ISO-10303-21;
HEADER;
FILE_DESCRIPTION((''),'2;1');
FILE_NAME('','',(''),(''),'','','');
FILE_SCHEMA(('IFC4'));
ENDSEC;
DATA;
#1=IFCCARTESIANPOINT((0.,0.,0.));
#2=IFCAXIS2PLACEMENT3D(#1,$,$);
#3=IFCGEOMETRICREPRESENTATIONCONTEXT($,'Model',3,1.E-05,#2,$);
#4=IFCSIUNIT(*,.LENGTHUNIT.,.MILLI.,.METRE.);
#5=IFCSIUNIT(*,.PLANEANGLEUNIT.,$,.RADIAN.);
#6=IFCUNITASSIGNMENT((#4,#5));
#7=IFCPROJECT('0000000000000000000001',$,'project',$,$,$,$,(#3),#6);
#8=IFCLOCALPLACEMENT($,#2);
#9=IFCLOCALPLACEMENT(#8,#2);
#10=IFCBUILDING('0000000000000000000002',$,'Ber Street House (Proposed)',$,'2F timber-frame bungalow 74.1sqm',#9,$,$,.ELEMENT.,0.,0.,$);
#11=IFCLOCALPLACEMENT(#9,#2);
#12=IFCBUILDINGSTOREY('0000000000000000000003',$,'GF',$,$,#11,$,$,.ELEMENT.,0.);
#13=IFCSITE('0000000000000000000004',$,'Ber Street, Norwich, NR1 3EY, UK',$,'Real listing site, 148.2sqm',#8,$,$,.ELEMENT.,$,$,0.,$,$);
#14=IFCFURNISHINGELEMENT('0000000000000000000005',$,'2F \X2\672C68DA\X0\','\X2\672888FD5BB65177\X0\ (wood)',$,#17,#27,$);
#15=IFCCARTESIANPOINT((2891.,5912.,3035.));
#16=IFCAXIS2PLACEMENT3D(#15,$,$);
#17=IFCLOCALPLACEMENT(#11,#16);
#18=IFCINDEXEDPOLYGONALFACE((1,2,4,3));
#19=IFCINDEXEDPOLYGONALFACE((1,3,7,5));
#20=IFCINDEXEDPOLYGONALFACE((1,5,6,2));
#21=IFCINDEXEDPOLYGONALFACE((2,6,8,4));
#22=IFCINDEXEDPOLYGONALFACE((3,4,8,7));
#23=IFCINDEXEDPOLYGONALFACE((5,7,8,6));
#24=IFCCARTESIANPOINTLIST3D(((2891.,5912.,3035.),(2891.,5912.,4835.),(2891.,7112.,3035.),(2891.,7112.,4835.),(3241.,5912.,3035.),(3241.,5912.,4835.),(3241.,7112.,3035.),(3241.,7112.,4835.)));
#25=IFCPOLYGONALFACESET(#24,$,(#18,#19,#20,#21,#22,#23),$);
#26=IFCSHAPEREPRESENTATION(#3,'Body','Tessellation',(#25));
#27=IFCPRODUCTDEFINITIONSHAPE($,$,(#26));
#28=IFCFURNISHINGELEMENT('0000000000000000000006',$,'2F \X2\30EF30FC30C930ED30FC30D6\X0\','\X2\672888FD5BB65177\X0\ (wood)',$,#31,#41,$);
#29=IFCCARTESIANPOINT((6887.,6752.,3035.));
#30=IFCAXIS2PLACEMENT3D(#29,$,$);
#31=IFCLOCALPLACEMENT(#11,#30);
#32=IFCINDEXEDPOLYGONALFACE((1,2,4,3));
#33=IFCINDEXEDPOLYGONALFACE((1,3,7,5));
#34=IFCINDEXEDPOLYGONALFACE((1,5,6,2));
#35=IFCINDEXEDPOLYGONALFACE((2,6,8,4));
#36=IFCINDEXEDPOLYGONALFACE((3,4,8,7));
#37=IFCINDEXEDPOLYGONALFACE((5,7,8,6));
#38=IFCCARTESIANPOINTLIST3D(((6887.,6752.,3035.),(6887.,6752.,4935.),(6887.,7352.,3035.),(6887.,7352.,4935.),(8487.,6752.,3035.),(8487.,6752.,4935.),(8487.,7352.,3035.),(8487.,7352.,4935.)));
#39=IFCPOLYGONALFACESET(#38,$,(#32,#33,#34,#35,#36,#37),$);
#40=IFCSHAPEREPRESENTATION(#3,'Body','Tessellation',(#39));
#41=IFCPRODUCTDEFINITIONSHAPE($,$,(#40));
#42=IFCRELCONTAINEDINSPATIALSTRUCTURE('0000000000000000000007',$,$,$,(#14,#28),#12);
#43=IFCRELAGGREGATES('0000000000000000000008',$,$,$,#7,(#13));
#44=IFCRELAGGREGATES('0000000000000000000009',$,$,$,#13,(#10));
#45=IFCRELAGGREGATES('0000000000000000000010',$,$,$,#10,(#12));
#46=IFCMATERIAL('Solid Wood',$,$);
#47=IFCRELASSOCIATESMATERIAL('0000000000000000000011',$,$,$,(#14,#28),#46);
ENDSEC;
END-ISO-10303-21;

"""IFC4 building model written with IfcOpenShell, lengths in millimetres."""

from ifc_helpers import new_model, si_unit, frame, frame_2d, origin, place, context, project, spatial, rectangle, extrude, material, element, save


model = new_model("IFC4")

# Units and contexts
model_context = context("Model", 3, precision=1e-05, world=origin())
ifc_project = project(units=[si_unit("LENGTHUNIT", "METRE", prefix="MILLI"), si_unit("PLANEANGLEUNIT", "RADIAN")], contexts=[model_context])

# Site, building, storey
site_placement = place(None, origin())
site = spatial("IfcSite", under=ifc_project, at=site_placement, Name="Ber Street, Norwich, NR1 3EY, UK", ObjectType="Real listing site, 148.2sqm", CompositionType="ELEMENT", RefElevation=0.0)
building_placement = place(site_placement, origin())
building = spatial("IfcBuilding", under=site, at=building_placement, Name="Ber Street House (Proposed)", ObjectType="2F timber-frame bungalow 74.1sqm", CompositionType="ELEMENT", ElevationOfRefHeight=0.0, ElevationOfTerrain=0.0)
storey_placement = place(building_placement, origin())
storey = spatial("IfcBuildingStorey", under=building, at=storey_placement, Name="GF", CompositionType="ELEMENT", Elevation=0.0)

# Shared definitions
ifc_material_1 = material(Name="Solid Wood")

# Furnishing elements
furnishing_1_placement = place(storey_placement, frame((2891.0, 5912.0, 3035.0)))
element("IfcFurnishingElement", 1, at=furnishing_1_placement, inside=storey, material=ifc_material_1, Name="2F 本棚", Description="木製家具 (wood)", context=model_context, shape_type="SweptSolid", body=[
    extrude(rectangle(XDim=350.0, YDim=1200.0, at=frame_2d((175.0, 600.0))), frame((2891.0, 5912.0, 3035.0)), (0.0, 0.0, 1.0), 1800.0),
])
furnishing_2_placement = place(storey_placement, frame((6887.0, 6752.0, 3035.0)))
element("IfcFurnishingElement", 2, at=furnishing_2_placement, inside=storey, material=ifc_material_1, Name="2F ワードローブ", Description="木製家具 (wood)", context=model_context, shape_type="SweptSolid", body=[
    extrude(rectangle(XDim=1600.0, YDim=600.0, at=frame_2d((800.0, 300.0))), frame((6887.0, 6752.0, 3035.0)), (0.0, 0.0, 1.0), 1900.0),
])

save(model, "model.ifc")
